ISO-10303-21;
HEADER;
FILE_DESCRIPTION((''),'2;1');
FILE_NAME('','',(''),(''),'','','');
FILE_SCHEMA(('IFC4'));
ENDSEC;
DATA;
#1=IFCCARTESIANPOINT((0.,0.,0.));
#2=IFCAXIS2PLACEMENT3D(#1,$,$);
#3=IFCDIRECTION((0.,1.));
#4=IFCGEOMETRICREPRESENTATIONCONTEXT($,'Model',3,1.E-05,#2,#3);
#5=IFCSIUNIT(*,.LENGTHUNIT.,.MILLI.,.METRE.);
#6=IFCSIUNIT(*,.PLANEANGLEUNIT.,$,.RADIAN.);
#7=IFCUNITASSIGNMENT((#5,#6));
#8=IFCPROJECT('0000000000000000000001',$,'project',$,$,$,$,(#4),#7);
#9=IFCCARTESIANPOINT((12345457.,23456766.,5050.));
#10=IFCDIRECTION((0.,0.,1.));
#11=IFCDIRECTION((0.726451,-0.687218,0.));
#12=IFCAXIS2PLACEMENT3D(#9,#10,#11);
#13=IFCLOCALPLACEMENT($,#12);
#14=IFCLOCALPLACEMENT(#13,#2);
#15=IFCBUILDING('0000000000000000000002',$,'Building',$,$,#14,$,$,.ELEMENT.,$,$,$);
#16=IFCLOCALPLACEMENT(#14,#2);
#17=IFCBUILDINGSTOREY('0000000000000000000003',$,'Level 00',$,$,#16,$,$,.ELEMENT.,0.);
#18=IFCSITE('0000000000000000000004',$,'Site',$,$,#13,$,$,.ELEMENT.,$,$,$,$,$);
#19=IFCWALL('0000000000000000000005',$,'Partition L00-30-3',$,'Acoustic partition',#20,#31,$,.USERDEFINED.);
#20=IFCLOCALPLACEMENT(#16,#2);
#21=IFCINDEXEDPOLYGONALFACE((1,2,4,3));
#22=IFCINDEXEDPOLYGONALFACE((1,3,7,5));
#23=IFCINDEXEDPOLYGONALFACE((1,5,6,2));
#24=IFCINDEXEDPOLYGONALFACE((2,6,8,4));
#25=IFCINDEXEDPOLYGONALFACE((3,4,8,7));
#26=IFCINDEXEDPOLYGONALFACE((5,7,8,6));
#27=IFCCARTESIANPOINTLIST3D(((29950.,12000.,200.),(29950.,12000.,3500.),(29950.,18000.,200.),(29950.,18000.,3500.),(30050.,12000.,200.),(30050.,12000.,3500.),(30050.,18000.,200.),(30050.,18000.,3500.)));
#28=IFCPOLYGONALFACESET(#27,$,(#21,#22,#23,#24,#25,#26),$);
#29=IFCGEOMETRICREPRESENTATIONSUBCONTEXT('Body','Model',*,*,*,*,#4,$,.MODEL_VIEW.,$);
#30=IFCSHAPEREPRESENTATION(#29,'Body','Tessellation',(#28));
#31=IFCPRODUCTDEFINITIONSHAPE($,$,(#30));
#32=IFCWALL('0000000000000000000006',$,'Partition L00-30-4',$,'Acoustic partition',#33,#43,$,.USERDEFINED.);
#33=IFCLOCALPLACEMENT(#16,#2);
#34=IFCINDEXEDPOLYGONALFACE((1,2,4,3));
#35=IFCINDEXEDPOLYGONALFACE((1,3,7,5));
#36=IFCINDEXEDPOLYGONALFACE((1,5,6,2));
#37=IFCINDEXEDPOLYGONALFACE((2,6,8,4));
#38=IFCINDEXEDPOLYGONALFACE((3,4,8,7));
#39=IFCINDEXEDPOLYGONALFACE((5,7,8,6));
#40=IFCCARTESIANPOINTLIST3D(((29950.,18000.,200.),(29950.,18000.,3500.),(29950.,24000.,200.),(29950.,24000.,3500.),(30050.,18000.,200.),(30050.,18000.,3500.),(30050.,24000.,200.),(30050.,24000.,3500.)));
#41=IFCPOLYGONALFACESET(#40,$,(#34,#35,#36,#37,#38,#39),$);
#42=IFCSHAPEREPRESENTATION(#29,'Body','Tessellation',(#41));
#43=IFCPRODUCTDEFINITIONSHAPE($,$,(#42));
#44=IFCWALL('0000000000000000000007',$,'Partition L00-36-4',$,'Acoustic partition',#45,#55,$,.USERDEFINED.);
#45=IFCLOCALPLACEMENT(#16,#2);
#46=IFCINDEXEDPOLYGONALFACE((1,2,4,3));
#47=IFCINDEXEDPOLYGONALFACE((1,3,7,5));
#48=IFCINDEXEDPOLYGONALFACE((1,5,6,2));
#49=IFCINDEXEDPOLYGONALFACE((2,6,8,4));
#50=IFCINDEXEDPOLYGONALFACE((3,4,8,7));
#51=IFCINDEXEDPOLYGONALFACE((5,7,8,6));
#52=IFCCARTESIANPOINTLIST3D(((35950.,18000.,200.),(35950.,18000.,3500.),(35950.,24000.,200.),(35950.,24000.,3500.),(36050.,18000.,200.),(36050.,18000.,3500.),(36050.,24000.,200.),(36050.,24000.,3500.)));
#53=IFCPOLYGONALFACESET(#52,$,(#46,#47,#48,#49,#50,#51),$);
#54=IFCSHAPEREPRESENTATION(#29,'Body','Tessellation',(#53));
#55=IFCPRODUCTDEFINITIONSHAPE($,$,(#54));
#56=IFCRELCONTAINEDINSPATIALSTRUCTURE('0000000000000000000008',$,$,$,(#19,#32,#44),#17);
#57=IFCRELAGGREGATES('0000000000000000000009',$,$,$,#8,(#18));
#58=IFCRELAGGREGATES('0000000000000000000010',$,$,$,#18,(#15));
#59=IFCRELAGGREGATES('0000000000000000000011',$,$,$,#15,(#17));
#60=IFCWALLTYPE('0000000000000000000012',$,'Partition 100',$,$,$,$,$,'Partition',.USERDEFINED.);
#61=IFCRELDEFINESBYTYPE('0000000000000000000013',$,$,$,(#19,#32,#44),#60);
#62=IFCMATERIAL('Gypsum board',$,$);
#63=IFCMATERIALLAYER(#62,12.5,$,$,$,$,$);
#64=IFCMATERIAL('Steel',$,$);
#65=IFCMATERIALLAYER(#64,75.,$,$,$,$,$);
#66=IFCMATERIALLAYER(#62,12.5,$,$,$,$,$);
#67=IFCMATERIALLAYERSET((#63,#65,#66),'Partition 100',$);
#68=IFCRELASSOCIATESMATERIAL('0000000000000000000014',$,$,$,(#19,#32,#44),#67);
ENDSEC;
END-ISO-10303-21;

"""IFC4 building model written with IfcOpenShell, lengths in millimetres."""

from ifc_helpers import new_model, si_unit, direction, frame, origin, place, context, subcontext, project, spatial, rectangle, extrude, material, layer, layer_set, layer_usage, type_object, element, save


model = new_model("IFC4")

# Units and contexts
model_context = context("Model", 3, precision=1e-05, world=origin(), true_north=direction((0.0, 1.0)))
body_context = subcontext(model_context, "Body", "Model", "MODEL_VIEW")
ifc_project = project(units=[si_unit("LENGTHUNIT", "METRE", prefix="MILLI"), si_unit("PLANEANGLEUNIT", "RADIAN")], contexts=[model_context])

# Site, building, storey
site_placement = place(None, frame((12345457.0, 23456766.0, 5050.0), z_axis=(0.0, 0.0, 1.0), x_axis=(0.726451, -0.687218, 0.0)))
site = spatial("IfcSite", under=ifc_project, at=site_placement, Name="Site", CompositionType="ELEMENT")
building_placement = place(site_placement, origin())
building = spatial("IfcBuilding", under=site, at=building_placement, Name="Building", CompositionType="ELEMENT")
storey_placement = place(building_placement, origin())
storey = spatial("IfcBuildingStorey", under=building, at=storey_placement, Name="Level 00", CompositionType="ELEMENT", Elevation=0.0)

# Shared definitions
ifc_material_1 = material(Name="Steel")

# Walls
ifc_material_2 = material(Name="Gypsum board")
ifc_layer_1 = layer(ifc_material_2, 12.5)
ifc_layer_2 = layer(ifc_material_1, 75.0)
ifc_layer_3 = layer(ifc_material_2, 12.5)
ifc_layer_set_1 = layer_set([ifc_layer_1, ifc_layer_2, ifc_layer_3], Name="Partition 100")
ifc_layer_usage_1 = layer_usage(ifc_layer_set_1, "AXIS2", "POSITIVE", 0.0)
wall_type_1 = type_object("IfcWallType", Name="Partition 100", ElementType="Partition", PredefinedType="USERDEFINED")
for number, where, name in (
    (1, (29950.0, 12000.0, 200.0), "Partition L00-30-3"),
    (2, (29950.0, 18000.0, 200.0), "Partition L00-30-4"),
    (3, (35950.0, 18000.0, 200.0), "Partition L00-36-4"),
):
    element("IfcWall", number, at=place(storey_placement, frame(where)), inside=storey, type_object=wall_type_1, material=ifc_layer_usage_1, Name=name, ObjectType="Acoustic partition", PredefinedType="USERDEFINED", context=body_context, shape_type="SweptSolid", body=[
        extrude(rectangle(XDim=100.0, YDim=6000.0), frame((50.0, 3000.0, 0.0)), (0.0, 0.0, 1.0), 3300.0),
    ])

save(model, "model.ifc")
